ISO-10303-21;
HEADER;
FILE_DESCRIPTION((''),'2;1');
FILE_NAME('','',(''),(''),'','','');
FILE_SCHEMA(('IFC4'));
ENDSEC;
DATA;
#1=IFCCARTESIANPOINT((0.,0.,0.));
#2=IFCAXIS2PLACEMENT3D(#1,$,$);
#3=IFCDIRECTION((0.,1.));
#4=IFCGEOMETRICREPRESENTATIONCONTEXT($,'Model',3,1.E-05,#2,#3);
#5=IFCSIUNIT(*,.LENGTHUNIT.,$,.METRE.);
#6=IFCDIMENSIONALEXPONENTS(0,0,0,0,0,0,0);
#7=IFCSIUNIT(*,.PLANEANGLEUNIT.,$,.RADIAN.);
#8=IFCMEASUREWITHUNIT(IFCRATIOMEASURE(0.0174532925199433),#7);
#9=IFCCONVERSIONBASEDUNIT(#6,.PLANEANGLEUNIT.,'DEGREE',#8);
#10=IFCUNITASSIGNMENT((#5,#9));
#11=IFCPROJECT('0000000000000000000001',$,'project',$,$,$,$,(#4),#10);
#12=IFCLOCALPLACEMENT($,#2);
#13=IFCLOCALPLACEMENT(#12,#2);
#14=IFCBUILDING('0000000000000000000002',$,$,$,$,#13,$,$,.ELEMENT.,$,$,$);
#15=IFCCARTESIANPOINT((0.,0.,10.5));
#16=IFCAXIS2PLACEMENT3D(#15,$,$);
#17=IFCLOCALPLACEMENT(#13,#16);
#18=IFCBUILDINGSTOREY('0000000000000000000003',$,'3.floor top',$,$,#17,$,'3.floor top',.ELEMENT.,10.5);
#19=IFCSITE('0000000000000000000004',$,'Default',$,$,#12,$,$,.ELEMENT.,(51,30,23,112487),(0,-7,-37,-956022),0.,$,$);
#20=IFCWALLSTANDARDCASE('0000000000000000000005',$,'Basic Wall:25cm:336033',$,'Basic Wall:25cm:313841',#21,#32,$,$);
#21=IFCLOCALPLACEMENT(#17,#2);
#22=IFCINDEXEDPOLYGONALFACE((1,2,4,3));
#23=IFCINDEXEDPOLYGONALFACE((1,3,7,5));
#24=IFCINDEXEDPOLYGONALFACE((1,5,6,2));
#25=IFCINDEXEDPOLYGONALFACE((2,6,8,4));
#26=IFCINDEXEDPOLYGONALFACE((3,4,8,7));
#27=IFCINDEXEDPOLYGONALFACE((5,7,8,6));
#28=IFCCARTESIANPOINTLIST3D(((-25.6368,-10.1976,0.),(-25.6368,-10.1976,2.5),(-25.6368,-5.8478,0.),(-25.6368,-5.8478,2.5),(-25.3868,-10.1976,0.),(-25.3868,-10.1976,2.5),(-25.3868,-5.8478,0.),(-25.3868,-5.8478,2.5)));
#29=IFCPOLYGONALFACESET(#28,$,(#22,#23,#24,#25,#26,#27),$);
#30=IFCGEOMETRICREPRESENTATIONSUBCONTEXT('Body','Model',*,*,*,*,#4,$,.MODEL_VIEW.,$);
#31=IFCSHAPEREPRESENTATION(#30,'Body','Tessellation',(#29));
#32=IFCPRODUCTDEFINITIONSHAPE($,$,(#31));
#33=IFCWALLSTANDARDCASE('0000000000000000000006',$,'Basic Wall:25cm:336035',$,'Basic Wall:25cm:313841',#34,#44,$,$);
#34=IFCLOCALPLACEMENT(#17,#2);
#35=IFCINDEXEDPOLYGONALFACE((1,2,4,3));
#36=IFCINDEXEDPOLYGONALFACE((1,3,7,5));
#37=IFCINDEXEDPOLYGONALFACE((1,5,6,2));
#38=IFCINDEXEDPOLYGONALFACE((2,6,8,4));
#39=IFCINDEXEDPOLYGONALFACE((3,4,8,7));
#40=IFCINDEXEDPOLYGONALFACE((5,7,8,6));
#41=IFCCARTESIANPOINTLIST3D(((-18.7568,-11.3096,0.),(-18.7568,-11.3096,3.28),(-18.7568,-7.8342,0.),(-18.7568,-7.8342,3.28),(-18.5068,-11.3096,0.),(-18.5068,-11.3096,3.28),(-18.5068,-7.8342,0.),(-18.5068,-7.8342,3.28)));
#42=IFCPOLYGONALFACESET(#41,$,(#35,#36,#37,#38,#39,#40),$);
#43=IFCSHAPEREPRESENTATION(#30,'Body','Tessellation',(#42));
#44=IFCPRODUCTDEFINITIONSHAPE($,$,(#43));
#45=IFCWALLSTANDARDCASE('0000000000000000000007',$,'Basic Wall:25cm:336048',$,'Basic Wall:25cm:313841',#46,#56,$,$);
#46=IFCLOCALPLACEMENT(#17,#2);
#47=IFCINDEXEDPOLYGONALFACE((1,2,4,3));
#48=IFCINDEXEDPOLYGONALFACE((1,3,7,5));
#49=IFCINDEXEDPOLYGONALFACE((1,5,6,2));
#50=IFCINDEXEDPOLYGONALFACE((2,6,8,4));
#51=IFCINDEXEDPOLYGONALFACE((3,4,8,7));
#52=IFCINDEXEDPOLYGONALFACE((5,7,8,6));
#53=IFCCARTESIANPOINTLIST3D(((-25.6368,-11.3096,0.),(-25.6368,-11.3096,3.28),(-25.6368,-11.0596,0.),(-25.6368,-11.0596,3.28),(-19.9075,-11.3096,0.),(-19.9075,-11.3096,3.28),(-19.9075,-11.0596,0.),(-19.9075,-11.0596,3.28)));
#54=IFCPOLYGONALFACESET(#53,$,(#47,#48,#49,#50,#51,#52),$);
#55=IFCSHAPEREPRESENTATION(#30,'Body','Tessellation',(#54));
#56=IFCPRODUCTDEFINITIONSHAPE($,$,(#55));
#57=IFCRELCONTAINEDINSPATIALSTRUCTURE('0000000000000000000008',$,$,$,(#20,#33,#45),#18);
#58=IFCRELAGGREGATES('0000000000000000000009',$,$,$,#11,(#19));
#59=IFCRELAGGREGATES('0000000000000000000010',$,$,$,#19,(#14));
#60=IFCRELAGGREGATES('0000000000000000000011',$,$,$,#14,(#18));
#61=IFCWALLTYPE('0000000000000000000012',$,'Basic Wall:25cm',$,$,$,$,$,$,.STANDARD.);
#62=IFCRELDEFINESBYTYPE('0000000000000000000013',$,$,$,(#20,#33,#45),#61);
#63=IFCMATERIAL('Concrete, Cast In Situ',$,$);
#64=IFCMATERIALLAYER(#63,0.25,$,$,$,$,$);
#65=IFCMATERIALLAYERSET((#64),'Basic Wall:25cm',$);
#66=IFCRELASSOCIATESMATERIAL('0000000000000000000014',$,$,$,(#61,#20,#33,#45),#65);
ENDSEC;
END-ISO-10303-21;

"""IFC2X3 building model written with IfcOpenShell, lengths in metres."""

from ifc_helpers import new_model, entity, si_unit, converted_unit, direction, frame, frame_2d, origin, place, context, subcontext, project, spatial, rectangle, extrude, material, layer, layer_set, layer_usage, type_object, element, save


model = new_model("IFC2X3")

# Units and contexts
model_context = context("Model", 3, precision=1e-05, world=origin(), true_north=direction((0.0, 1.0)))
body_context = subcontext(model_context, "Body", "Model", "MODEL_VIEW")
ifc_project = project(units=[si_unit("LENGTHUNIT", "METRE"), converted_unit("PLANEANGLEUNIT", "DEGREE", entity("IfcRatioMeasure", 0.0174532925199433), si_unit("PLANEANGLEUNIT", "RADIAN"), dimensions=[0, 0, 0, 0, 0, 0, 0])], contexts=[model_context])

# Site, building, storey
site_placement = place(None, origin())
site = spatial("IfcSite", under=ifc_project, at=site_placement, Name="Default", CompositionType="ELEMENT", RefLatitude=(51, 30, 23, 112487), RefLongitude=(0, -7, -37, -956022), RefElevation=0.0)
building_placement = place(site_placement, origin())
building = spatial("IfcBuilding", under=site, at=building_placement, CompositionType="ELEMENT")
storey_placement = place(building_placement, frame((0.0, 0.0, 10.5)))
storey = spatial("IfcBuildingStorey", under=building, at=storey_placement, Name="3.floor top", LongName="3.floor top", CompositionType="ELEMENT", Elevation=10.5)

# Shared definitions
ifc_material = material(Name="Concrete, Cast In Situ")
ifc_layer = layer(ifc_material, 0.25)
ifc_layer_set = layer_set([ifc_layer], Name="Basic Wall:25cm")
wall_type = type_object("IfcWallType", Name="Basic Wall:25cm", PredefinedType="STANDARD", material=ifc_layer_set)

# Walls
ifc_layer_usage_1 = layer_usage(ifc_layer_set, "AXIS2", "NEGATIVE", 0.125)
wall_1_placement = place(storey_placement, frame((-25.5118, -5.8478, 0.0), z_axis=(0.0, 0.0, 1.0), x_axis=(0.0, -1.0, 0.0)))
element("IfcWallStandardCase", 1, at=wall_1_placement, inside=storey, type_object=wall_type, material=ifc_layer_usage_1, Name="Basic Wall:25cm:336033", ObjectType="Basic Wall:25cm:313841", context=body_context, shape_type="SweptSolid", body=[
    extrude(rectangle(XDim=4.3498, YDim=0.25, at=frame_2d((2.1749, 0.0), x_axis=(-1.0, 0.0))), origin(), (0.0, 0.0, 1.0), 2.5),
])
ifc_layer_usage_2 = layer_usage(ifc_layer_set, "AXIS2", "POSITIVE", -0.125)
wall_2_placement = place(storey_placement, frame((-18.6318, -7.8342, 0.0), z_axis=(0.0, 0.0, 1.0), x_axis=(0.0, -1.0, 0.0)))
element("IfcWallStandardCase", 2, at=wall_2_placement, inside=storey, type_object=wall_type, material=ifc_layer_usage_2, Name="Basic Wall:25cm:336035", ObjectType="Basic Wall:25cm:313841", context=body_context, shape_type="SweptSolid", body=[
    extrude(rectangle(XDim=3.4754, YDim=0.25, at=frame_2d((1.7377, 0.0), x_axis=(-1.0, 0.0))), origin(), (0.0, 0.0, 1.0), 3.28),
])
ifc_layer_usage_3 = layer_usage(ifc_layer_set, "AXIS2", "NEGATIVE", 0.125)
wall_3_placement = place(storey_placement, frame((-25.6368, -11.1846, 0.0)))
element("IfcWallStandardCase", 3, at=wall_3_placement, inside=storey, type_object=wall_type, material=ifc_layer_usage_3, Name="Basic Wall:25cm:336048", ObjectType="Basic Wall:25cm:313841", context=body_context, shape_type="SweptSolid", body=[
    extrude(rectangle(XDim=5.7293, YDim=0.25, at=frame_2d((2.8646, 0.0), x_axis=(-1.0, 0.0))), origin(), (0.0, 0.0, 1.0), 3.28),
])

save(model, "model.ifc")
